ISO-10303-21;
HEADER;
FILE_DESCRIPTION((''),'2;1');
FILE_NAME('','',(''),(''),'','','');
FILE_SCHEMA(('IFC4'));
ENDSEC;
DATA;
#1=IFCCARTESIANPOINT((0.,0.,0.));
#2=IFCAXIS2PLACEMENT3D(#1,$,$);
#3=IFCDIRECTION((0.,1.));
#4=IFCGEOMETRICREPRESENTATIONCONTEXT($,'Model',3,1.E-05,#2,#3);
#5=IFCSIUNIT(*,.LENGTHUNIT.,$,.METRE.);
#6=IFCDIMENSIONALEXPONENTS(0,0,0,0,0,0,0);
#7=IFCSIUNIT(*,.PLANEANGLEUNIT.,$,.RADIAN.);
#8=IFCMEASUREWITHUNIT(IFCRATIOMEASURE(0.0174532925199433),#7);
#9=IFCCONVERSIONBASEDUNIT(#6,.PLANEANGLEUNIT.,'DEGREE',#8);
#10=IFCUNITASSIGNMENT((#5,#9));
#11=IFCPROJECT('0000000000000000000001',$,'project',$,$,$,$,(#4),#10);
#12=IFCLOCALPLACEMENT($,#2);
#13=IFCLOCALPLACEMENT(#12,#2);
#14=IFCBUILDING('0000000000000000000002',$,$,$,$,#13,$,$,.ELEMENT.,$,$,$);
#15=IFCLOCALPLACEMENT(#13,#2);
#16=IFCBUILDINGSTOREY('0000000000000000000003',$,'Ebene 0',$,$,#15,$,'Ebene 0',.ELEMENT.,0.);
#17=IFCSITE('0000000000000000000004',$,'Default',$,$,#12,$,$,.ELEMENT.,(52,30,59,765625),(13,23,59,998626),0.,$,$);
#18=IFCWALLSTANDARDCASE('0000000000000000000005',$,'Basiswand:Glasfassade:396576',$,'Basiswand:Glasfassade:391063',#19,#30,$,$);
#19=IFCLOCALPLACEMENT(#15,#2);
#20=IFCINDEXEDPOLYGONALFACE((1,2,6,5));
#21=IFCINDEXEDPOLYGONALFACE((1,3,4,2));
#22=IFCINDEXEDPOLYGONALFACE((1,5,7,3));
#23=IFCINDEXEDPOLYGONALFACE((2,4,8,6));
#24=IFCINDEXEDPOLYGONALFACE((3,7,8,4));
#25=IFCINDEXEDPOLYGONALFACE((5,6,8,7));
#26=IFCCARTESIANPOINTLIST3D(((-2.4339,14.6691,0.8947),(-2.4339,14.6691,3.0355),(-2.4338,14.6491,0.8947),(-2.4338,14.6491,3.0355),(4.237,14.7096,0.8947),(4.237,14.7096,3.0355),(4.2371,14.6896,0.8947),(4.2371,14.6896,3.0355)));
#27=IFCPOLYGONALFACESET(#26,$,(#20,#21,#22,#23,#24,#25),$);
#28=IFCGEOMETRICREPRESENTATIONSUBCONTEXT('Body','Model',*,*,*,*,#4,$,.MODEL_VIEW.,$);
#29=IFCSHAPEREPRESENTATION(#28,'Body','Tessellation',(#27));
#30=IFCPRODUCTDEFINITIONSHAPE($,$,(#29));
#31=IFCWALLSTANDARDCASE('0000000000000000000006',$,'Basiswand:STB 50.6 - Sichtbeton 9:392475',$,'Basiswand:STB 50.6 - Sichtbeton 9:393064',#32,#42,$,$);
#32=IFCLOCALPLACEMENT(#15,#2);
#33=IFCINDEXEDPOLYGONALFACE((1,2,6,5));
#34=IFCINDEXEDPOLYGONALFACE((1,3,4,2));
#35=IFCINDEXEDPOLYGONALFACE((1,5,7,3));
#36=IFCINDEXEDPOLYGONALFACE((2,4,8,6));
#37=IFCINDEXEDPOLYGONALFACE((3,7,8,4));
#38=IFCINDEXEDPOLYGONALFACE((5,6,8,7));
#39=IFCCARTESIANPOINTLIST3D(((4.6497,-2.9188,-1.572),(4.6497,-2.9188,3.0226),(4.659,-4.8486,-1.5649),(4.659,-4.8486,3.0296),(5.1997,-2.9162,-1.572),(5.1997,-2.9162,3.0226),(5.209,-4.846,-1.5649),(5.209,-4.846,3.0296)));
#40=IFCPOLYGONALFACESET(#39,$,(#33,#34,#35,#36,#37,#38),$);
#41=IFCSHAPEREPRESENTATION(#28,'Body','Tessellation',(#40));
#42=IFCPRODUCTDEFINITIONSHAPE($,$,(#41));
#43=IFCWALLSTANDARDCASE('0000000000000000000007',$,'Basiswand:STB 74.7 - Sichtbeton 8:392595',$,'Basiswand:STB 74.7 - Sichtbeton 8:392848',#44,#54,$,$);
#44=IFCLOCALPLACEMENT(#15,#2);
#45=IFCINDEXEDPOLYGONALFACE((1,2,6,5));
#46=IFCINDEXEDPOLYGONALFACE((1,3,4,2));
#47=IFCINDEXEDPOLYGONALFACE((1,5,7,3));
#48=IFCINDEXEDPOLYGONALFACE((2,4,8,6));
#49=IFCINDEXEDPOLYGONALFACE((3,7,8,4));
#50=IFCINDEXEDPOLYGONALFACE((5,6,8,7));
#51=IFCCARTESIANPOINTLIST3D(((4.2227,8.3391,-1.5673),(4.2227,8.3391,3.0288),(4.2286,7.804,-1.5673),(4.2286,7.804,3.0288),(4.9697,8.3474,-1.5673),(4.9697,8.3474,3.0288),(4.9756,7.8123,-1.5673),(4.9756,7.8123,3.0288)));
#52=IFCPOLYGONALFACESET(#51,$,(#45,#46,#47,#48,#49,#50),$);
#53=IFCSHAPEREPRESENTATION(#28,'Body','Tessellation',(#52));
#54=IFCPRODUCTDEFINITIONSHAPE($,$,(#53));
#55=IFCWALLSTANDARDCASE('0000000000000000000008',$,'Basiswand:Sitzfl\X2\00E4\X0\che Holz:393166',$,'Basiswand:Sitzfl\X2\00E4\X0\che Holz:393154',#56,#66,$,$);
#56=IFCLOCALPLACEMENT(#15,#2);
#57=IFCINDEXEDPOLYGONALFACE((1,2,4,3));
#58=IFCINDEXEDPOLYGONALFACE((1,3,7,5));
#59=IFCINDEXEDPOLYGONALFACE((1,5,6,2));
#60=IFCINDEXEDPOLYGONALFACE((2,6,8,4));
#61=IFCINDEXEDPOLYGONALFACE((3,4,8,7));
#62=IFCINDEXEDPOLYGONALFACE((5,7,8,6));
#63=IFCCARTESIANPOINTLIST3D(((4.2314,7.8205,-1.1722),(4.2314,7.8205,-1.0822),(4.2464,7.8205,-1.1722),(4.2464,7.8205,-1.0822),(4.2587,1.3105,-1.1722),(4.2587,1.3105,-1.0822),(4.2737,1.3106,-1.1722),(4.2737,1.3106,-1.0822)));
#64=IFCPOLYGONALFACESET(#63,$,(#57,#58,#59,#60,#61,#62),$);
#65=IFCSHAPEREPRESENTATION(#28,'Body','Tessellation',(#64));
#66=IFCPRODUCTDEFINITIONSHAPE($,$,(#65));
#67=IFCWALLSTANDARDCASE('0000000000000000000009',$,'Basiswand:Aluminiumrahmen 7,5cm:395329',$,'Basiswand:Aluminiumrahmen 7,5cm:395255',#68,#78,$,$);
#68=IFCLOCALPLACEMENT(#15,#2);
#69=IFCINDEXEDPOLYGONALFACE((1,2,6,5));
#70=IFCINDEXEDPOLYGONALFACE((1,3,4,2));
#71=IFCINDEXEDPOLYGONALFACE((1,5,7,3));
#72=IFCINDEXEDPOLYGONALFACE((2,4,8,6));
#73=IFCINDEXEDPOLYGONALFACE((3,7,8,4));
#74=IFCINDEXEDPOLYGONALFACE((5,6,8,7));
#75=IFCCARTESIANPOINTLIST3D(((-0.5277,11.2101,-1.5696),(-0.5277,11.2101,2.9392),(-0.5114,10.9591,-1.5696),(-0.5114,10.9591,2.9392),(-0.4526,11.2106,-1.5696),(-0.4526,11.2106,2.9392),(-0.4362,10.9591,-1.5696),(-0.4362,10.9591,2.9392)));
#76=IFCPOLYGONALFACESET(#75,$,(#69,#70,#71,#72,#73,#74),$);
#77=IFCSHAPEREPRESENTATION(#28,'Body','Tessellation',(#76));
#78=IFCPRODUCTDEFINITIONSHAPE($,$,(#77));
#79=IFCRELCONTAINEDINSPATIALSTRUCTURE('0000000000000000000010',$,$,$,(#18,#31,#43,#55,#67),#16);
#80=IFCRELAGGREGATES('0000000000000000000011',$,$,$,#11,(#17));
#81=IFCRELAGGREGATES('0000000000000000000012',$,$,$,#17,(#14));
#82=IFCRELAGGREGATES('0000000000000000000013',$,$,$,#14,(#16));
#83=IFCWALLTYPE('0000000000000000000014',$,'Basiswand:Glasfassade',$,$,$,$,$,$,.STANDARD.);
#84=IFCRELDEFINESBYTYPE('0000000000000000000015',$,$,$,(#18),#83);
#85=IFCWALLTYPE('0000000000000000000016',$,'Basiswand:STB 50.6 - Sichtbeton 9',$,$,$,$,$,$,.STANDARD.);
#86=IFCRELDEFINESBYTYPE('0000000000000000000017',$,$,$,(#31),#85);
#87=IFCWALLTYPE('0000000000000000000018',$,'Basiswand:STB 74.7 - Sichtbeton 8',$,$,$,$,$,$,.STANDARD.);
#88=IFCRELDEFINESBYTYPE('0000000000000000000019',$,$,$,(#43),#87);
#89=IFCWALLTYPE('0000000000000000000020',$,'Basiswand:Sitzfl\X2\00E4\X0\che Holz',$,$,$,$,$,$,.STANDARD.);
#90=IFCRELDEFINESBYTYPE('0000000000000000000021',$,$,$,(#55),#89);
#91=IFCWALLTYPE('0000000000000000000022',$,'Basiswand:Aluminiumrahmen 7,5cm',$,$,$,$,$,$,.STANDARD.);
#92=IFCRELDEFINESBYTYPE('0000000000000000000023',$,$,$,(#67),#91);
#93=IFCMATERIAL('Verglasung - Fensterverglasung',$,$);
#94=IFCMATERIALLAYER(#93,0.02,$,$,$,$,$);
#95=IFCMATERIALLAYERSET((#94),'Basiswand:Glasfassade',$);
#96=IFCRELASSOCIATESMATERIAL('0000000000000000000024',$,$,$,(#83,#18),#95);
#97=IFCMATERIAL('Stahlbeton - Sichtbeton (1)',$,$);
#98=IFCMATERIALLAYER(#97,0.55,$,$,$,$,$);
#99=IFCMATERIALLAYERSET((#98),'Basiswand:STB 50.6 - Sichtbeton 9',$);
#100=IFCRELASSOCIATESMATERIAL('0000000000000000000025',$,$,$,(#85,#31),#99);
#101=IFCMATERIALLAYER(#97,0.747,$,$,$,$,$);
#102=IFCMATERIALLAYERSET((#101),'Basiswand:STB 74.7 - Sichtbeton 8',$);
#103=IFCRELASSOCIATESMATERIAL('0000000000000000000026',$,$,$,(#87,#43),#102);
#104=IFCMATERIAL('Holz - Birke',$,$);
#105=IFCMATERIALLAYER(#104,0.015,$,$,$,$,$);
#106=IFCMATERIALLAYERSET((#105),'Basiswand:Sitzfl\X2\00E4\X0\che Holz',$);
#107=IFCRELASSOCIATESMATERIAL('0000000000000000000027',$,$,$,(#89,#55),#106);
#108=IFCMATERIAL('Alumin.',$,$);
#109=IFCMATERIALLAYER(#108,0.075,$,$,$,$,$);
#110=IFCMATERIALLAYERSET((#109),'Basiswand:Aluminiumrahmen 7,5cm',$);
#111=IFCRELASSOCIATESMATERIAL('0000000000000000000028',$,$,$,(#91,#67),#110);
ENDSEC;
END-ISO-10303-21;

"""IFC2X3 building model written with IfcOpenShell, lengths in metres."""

from ifc_helpers import new_model, entity, si_unit, converted_unit, direction, frame, frame_2d, origin, place, context, subcontext, project, spatial, polyline, rectangle, outline, extrude, material, layer, layer_set, layer_usage, type_object, element, save


model = new_model("IFC2X3")

# Units and contexts
model_context = context("Model", 3, precision=1e-05, world=origin(), true_north=direction((0.0, 1.0)))
body_context = subcontext(model_context, "Body", "Model", "MODEL_VIEW")
ifc_project = project(units=[si_unit("LENGTHUNIT", "METRE"), converted_unit("PLANEANGLEUNIT", "DEGREE", entity("IfcRatioMeasure", 0.0174532925199433), si_unit("PLANEANGLEUNIT", "RADIAN"), dimensions=[0, 0, 0, 0, 0, 0, 0])], contexts=[model_context])

# Site, building, storey
site_placement = place(None, origin())
site = spatial("IfcSite", under=ifc_project, at=site_placement, Name="Default", CompositionType="ELEMENT", RefLatitude=(52, 30, 59, 765625), RefLongitude=(13, 23, 59, 998626), RefElevation=0.0)
building_placement = place(site_placement, origin())
building = spatial("IfcBuilding", under=site, at=building_placement, CompositionType="ELEMENT")
storey_placement = place(building_placement, origin())
storey = spatial("IfcBuildingStorey", under=building, at=storey_placement, Name="Ebene 0", LongName="Ebene 0", CompositionType="ELEMENT", Elevation=0.0)

# Walls
ifc_material_1 = material(Name="Stahlbeton - Sichtbeton (1)")
ifc_material_2 = material(Name="Alumin.")
ifc_material_3 = material(Name="Verglasung - Fensterverglasung")
ifc_layer_1 = layer(ifc_material_3, 0.02)
ifc_layer_set_1 = layer_set([ifc_layer_1], Name="Basiswand:Glasfassade")
wall_type_1 = type_object("IfcWallType", Name="Basiswand:Glasfassade", PredefinedType="STANDARD", material=ifc_layer_set_1)
ifc_layer_usage_1 = layer_usage(ifc_layer_set_1, "AXIS2", "POSITIVE", -0.01)
wall_1_placement = place(storey_placement, frame((4.237, 14.6996, 0.8947), z_axis=(0.0, 0.0, 1.0), x_axis=(-0.999982, -0.006064, 0.0)))
element("IfcWallStandardCase", 1, at=wall_1_placement, inside=storey, type_object=wall_type_1, material=ifc_layer_usage_1, Name="Basiswand:Glasfassade:396576", ObjectType="Basiswand:Glasfassade:391063", context=body_context, shape_type="SweptSolid", body=[
    extrude(rectangle(XDim=6.671, YDim=0.02, at=frame_2d((3.3355, 0.0), x_axis=(-1.0, 0.0))), origin(), (0.0, 0.0, 1.0), 2.1408),
])
ifc_layer_2 = layer(ifc_material_1, 0.55)
ifc_layer_set_2 = layer_set([ifc_layer_2], Name="Basiswand:STB 50.6 - Sichtbeton 9")
ifc_layer_usage_2 = layer_usage(ifc_layer_set_2, "AXIS2", "POSITIVE", -0.275)
wall_type_2 = type_object("IfcWallType", Name="Basiswand:STB 50.6 - Sichtbeton 9", PredefinedType="STANDARD", material=ifc_layer_set_2)
wall_2_placement = place(storey_placement, frame((4.934, -4.8473, -1.572), z_axis=(0.0, 0.0, 1.0), x_axis=(-0.004808, 0.999988, 0.0)))
element("IfcWallStandardCase", 2, at=wall_2_placement, inside=storey, type_object=wall_type_2, material=ifc_layer_usage_2, Name="Basiswand:STB 50.6 - Sichtbeton 9:392475", ObjectType="Basiswand:STB 50.6 - Sichtbeton 9:393064", context=body_context, shape_type="SweptSolid", body=[
    extrude(outline(polyline([(-0.275, -0.9649), (0.275, -0.9649), (0.275, 0.9649), (-0.275, 0.965), (-0.275, -0.9649)])), frame((0.9649, 0.0, 0.0035), z_axis=(0.003655, 0.0, 0.999993), x_axis=(0.0, 1.0, 0.0)), (0.0, 0.003655, 0.999993), 4.5945),
])
ifc_layer_3 = layer(ifc_material_1, 0.747)
ifc_layer_set_3 = layer_set([ifc_layer_3], Name="Basiswand:STB 74.7 - Sichtbeton 8")
ifc_layer_usage_3 = layer_usage(ifc_layer_set_3, "AXIS2", "POSITIVE", -0.3735)
wall_type_3 = type_object("IfcWallType", Name="Basiswand:STB 74.7 - Sichtbeton 8", PredefinedType="STANDARD", material=ifc_layer_set_3)
wall_3_placement = place(storey_placement, frame((4.5962, 8.3432, -1.5673), z_axis=(0.0, 0.0, 1.0), x_axis=(0.011075, -0.999939, 0.0)))
element("IfcWallStandardCase", 3, at=wall_3_placement, inside=storey, type_object=wall_type_3, material=ifc_layer_usage_3, Name="Basiswand:STB 74.7 - Sichtbeton 8:392595", ObjectType="Basiswand:STB 74.7 - Sichtbeton 8:392848", context=body_context, shape_type="SweptSolid", body=[
    extrude(rectangle(XDim=0.5351, YDim=0.747, at=frame_2d((0.2676, 0.0), x_axis=(-1.0, 0.0))), origin(), (0.0, 0.0, 1.0), 4.5961),
])
ifc_material_4 = material(Name="Holz - Birke")
ifc_layer_4 = layer(ifc_material_4, 0.015)
ifc_layer_set_4 = layer_set([ifc_layer_4], Name="Basiswand:Sitzfläche Holz")
ifc_layer_usage_4 = layer_usage(ifc_layer_set_4, "AXIS2", "POSITIVE", -0.0075)
wall_type_4 = type_object("IfcWallType", Name="Basiswand:Sitzfläche Holz", PredefinedType="STANDARD", material=ifc_layer_set_4)
wall_4_placement = place(storey_placement, frame((4.2389, 7.8205, -1.1722), z_axis=(0.0, 0.0, 1.0), x_axis=(0.004191, -0.999991, 0.0)))
element("IfcWallStandardCase", 4, at=wall_4_placement, inside=storey, type_object=wall_type_4, material=ifc_layer_usage_4, Name="Basiswand:Sitzfläche Holz:393166", ObjectType="Basiswand:Sitzfläche Holz:393154", context=body_context, shape_type="SweptSolid", body=[
    extrude(rectangle(XDim=6.51, YDim=0.015, at=frame_2d((3.255, 0.0), x_axis=(-1.0, 0.0))), origin(), (0.0, 0.0, 1.0), 0.09),
])
ifc_layer_5 = layer(ifc_material_2, 0.075)
ifc_layer_set_5 = layer_set([ifc_layer_5], Name="Basiswand:Aluminiumrahmen 7,5cm")
ifc_layer_usage_5 = layer_usage(ifc_layer_set_5, "AXIS2", "POSITIVE", -0.0375)
wall_type_5 = type_object("IfcWallType", Name="Basiswand:Aluminiumrahmen 7,5cm", PredefinedType="STANDARD", material=ifc_layer_set_5)
wall_5_placement = place(storey_placement, frame((-0.4903, 11.2125, -1.5696), z_axis=(0.0, 0.0, 1.0), x_axis=(0.064997, -0.997885, 0.0)))
element("IfcWallStandardCase", 5, at=wall_5_placement, inside=storey, type_object=wall_type_5, material=ifc_layer_usage_5, Name="Basiswand:Aluminiumrahmen 7,5cm:395329", ObjectType="Basiswand:Aluminiumrahmen 7,5cm:395255", context=body_context, shape_type="SweptSolid", body=[
    extrude(outline(polyline([(0.2515, -0.0375), (0.2564, 0.0375), (0.0043, 0.0375), (0.0, -0.0375), (0.2515, -0.0375)])), origin(), (0.0, 0.0, 1.0), 4.5088),
])

save(model, "model.ifc")
